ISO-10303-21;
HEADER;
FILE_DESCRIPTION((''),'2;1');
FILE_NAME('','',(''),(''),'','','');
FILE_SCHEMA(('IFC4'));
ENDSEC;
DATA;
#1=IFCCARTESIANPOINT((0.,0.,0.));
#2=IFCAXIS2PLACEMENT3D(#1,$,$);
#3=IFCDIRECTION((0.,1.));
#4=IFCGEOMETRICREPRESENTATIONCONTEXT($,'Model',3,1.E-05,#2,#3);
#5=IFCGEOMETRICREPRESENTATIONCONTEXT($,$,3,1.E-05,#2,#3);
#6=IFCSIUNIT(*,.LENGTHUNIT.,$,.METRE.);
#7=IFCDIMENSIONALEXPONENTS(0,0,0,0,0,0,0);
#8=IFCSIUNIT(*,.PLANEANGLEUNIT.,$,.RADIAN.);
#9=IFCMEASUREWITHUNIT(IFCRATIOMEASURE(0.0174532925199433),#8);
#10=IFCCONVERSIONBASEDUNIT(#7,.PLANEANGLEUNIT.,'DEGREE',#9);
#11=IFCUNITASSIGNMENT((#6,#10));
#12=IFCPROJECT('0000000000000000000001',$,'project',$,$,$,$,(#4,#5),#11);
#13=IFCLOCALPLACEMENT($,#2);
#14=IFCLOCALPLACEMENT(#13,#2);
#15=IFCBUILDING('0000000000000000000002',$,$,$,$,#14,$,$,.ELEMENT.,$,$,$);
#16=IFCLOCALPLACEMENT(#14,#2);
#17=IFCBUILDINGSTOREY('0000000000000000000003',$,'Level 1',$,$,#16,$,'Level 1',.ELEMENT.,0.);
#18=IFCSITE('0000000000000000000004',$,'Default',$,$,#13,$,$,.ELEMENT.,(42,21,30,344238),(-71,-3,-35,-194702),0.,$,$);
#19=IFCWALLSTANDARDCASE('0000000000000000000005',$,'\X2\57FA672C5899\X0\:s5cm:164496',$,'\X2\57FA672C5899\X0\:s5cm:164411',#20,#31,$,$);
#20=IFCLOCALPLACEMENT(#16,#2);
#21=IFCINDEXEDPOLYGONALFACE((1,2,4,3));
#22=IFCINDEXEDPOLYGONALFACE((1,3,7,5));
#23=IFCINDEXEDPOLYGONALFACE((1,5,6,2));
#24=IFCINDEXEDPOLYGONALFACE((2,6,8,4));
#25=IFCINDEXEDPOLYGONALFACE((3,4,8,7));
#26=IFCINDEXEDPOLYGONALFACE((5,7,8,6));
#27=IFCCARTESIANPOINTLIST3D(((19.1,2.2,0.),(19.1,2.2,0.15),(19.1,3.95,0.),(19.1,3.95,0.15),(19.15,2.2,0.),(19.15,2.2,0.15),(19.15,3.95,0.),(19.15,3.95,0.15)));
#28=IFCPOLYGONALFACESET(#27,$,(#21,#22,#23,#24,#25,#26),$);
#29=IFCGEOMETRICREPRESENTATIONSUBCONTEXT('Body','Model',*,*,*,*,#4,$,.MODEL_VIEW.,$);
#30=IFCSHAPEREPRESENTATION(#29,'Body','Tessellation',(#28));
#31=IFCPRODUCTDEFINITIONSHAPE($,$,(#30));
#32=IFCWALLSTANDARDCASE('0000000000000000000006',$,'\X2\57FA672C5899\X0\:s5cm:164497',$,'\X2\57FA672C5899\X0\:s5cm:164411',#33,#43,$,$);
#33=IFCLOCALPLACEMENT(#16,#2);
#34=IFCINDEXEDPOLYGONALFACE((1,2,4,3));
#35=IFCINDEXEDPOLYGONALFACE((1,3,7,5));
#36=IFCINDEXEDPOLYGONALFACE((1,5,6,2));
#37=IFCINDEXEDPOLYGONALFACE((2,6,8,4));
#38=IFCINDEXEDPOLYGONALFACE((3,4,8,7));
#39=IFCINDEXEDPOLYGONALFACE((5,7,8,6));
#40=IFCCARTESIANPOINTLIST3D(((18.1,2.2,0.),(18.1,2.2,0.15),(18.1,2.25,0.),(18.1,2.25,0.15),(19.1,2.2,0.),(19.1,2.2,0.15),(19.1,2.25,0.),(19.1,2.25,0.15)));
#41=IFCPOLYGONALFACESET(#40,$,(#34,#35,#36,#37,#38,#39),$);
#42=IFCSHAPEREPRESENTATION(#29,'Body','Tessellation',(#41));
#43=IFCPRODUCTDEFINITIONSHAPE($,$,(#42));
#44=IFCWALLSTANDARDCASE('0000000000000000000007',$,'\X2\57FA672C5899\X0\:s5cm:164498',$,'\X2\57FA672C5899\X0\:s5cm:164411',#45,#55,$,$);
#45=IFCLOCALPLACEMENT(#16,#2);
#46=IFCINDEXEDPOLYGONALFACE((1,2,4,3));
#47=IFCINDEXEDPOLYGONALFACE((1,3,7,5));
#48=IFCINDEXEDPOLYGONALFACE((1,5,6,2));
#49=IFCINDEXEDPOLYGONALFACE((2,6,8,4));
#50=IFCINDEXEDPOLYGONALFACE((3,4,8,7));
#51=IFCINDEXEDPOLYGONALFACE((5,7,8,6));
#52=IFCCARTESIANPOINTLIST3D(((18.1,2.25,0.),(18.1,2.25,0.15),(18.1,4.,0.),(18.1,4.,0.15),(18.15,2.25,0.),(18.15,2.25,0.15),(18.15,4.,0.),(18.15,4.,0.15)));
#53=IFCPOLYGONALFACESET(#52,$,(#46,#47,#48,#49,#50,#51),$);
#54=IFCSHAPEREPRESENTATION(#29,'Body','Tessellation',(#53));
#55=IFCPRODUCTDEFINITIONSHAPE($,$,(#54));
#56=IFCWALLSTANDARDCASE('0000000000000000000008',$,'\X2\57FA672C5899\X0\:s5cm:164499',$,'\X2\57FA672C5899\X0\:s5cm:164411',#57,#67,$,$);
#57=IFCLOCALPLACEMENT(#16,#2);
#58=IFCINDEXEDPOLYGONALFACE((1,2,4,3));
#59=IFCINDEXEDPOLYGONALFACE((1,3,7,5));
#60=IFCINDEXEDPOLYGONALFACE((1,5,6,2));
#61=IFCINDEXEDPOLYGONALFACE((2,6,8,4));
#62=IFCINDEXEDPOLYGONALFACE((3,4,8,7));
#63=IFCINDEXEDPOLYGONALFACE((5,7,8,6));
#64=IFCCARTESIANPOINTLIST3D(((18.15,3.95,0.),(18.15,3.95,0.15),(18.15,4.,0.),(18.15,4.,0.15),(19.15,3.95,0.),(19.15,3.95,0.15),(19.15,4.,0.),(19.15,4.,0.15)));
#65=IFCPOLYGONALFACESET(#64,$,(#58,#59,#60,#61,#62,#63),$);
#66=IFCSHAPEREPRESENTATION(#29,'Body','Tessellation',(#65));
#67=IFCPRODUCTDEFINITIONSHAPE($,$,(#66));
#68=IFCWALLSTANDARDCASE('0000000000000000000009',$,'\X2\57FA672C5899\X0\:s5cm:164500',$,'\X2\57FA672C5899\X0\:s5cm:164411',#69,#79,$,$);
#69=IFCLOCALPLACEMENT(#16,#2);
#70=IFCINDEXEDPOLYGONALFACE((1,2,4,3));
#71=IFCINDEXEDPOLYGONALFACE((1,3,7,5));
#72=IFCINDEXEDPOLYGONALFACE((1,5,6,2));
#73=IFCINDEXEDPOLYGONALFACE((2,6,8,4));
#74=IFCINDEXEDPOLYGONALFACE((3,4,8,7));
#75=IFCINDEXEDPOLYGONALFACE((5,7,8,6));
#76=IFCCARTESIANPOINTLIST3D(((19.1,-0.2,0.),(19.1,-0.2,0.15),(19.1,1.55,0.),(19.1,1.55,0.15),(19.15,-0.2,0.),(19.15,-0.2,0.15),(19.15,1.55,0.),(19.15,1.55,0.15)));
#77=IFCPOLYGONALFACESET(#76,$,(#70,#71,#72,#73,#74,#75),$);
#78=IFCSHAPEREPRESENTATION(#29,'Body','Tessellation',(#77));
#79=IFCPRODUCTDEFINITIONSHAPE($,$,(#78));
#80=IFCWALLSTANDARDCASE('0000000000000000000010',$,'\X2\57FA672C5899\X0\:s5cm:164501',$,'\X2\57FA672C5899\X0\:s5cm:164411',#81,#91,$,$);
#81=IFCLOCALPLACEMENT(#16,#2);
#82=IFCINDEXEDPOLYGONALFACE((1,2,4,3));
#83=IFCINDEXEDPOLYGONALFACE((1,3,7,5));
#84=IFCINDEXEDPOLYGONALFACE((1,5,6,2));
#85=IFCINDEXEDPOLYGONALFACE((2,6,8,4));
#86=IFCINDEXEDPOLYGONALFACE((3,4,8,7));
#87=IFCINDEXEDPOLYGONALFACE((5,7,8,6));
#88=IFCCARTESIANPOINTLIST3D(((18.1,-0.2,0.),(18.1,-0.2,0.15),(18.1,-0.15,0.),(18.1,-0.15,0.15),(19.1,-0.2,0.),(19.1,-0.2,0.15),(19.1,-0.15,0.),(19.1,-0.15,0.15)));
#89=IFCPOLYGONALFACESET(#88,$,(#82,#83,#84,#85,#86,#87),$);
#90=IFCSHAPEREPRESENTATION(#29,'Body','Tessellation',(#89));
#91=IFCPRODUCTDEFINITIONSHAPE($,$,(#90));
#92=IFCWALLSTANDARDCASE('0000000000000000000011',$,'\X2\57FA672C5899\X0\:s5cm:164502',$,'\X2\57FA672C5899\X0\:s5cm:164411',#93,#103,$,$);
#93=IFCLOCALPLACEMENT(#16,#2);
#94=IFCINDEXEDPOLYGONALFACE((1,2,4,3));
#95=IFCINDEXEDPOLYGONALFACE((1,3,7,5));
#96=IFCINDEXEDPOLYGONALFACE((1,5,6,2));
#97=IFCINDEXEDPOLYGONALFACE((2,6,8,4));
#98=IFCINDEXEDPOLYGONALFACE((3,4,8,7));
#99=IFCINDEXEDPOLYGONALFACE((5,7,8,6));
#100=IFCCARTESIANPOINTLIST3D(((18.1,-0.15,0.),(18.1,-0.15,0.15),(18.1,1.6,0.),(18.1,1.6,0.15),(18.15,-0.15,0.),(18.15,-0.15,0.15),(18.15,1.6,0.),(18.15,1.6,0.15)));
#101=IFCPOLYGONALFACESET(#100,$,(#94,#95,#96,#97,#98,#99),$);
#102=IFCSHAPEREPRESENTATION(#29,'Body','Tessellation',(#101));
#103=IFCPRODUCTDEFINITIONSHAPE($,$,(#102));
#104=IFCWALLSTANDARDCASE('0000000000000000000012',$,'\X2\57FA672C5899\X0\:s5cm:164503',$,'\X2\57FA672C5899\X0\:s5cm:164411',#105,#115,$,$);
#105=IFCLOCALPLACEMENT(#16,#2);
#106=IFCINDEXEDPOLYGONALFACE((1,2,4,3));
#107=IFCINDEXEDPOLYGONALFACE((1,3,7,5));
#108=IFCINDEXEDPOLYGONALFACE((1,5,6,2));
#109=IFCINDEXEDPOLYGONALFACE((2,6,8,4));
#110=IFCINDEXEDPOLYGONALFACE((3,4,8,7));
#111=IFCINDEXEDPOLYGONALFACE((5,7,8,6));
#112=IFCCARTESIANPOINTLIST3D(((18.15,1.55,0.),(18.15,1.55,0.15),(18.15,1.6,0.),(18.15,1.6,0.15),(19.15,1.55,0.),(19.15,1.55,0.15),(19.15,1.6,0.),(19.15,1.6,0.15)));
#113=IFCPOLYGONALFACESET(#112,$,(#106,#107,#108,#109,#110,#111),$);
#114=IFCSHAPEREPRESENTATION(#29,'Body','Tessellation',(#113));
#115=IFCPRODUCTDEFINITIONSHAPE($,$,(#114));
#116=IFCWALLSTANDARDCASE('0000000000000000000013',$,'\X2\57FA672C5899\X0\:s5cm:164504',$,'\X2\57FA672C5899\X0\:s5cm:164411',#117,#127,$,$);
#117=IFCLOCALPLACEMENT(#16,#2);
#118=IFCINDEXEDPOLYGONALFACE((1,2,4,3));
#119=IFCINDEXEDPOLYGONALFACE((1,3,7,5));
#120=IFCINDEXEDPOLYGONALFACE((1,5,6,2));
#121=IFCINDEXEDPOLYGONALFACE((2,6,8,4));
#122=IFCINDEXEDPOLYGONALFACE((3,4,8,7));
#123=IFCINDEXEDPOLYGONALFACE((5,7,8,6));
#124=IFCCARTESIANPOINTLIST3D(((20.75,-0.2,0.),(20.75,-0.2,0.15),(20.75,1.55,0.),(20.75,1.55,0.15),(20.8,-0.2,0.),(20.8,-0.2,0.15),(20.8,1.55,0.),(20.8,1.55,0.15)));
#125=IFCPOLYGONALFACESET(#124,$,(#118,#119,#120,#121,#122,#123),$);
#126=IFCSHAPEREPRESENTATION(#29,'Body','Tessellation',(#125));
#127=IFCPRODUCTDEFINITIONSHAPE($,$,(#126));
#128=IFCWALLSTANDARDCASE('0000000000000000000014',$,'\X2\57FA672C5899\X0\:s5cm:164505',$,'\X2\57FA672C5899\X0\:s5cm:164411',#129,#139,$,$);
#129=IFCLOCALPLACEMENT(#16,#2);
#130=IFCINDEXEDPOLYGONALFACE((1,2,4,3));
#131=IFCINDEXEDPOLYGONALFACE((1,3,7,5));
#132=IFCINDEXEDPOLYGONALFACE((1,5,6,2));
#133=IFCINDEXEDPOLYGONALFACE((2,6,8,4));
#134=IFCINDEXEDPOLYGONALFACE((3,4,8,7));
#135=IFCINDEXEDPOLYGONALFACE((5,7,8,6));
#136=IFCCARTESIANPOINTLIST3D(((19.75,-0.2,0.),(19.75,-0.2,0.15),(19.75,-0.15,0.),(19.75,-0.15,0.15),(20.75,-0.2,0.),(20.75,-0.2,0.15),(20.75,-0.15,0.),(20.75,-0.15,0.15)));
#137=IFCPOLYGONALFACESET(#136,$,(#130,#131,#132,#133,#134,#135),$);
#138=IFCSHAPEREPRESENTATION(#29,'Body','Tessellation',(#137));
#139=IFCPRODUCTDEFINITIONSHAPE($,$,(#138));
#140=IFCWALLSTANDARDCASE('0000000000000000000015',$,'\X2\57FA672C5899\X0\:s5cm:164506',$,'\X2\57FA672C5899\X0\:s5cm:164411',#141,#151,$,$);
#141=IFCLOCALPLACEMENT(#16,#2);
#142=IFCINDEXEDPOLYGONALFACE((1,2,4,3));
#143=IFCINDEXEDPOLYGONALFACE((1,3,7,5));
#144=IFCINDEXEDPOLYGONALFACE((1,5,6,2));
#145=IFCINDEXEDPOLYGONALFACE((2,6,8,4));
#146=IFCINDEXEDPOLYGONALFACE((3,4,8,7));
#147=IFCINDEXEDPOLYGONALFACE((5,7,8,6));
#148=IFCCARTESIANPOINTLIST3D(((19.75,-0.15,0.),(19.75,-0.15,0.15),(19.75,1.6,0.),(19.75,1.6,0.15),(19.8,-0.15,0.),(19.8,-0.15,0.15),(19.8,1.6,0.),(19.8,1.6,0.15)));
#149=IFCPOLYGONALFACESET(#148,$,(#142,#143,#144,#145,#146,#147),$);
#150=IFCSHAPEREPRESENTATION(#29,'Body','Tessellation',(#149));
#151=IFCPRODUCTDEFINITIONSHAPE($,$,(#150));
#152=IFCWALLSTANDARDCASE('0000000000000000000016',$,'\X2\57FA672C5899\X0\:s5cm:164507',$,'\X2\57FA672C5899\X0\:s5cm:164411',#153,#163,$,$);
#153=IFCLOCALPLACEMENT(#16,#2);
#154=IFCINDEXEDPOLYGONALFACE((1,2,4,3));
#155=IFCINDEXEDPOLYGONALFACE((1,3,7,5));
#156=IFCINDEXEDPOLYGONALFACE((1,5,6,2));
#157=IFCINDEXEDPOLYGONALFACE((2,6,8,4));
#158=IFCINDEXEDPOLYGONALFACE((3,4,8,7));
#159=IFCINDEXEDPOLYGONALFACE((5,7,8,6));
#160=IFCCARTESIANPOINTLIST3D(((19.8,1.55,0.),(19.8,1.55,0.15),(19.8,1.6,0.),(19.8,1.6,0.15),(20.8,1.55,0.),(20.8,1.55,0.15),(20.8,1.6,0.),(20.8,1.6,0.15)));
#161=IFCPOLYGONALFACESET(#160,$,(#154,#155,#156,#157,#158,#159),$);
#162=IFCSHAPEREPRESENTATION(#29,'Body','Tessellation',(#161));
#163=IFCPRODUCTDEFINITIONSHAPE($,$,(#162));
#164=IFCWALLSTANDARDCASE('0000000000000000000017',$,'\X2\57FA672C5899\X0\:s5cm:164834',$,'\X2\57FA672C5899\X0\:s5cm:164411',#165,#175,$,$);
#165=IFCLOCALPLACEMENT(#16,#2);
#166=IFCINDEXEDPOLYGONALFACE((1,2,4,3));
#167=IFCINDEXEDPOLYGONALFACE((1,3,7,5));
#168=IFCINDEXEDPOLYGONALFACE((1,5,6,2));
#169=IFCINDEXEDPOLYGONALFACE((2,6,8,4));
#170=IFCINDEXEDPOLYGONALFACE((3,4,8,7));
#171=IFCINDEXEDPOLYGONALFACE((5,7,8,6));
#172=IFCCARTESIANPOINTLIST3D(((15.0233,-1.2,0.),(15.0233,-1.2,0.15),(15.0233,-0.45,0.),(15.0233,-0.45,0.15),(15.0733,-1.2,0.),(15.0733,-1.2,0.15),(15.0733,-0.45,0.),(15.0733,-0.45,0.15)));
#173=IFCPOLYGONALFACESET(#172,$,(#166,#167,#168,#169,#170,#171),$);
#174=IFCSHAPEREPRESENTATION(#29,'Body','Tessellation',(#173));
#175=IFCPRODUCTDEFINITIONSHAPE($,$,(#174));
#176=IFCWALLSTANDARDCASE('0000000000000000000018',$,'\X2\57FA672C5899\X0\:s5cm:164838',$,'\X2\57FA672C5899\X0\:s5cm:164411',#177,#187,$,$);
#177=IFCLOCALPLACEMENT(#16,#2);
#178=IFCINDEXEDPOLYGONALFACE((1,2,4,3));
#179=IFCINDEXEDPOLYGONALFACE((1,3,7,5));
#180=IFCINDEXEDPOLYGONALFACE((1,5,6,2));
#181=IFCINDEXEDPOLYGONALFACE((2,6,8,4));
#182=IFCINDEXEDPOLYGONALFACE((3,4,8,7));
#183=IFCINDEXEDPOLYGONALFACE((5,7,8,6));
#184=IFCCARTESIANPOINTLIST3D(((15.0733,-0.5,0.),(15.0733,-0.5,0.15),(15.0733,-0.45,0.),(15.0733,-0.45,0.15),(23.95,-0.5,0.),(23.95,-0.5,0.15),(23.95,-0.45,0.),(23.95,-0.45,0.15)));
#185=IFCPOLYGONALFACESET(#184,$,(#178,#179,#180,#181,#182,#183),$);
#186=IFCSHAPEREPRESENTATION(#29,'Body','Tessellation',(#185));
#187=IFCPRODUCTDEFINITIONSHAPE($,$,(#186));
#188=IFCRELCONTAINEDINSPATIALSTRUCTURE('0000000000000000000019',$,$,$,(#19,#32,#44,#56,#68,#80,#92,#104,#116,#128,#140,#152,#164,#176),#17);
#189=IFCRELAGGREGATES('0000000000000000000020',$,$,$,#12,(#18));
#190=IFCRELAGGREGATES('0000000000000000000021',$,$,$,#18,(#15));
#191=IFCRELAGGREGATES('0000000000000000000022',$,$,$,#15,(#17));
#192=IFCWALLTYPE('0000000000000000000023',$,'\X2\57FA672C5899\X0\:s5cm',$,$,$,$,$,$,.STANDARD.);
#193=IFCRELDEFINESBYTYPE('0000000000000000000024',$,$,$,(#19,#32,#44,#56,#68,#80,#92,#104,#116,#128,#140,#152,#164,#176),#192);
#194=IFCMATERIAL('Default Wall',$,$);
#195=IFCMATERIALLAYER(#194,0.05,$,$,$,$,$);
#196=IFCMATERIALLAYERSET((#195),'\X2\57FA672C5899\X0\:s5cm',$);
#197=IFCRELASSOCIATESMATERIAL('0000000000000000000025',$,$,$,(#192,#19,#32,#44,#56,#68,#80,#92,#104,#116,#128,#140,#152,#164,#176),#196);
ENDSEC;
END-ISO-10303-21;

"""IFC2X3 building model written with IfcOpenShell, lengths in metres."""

from ifc_helpers import new_model, entity, si_unit, converted_unit, direction, frame, frame_2d, origin, place, context, subcontext, project, spatial, rectangle, extrude, material, layer, layer_set, layer_usage, type_object, element, save


model = new_model("IFC2X3")

# Units and contexts
model_context = context("Model", 3, precision=1e-05, world=origin(), true_north=direction((0.0, 1.0)))
context_of_model = context(None, 3, precision=1e-05, world=origin(), true_north=direction((0.0, 1.0)))
body_context = subcontext(model_context, "Body", "Model", "MODEL_VIEW")
ifc_project = project(units=[si_unit("LENGTHUNIT", "METRE"), converted_unit("PLANEANGLEUNIT", "DEGREE", entity("IfcRatioMeasure", 0.0174532925199433), si_unit("PLANEANGLEUNIT", "RADIAN"), dimensions=[0, 0, 0, 0, 0, 0, 0])], contexts=[model_context, context_of_model])

# Site, building, storey
site_placement = place(None, origin())
site = spatial("IfcSite", under=ifc_project, at=site_placement, Name="Default", CompositionType="ELEMENT", RefLatitude=(42, 21, 30, 344238), RefLongitude=(-71, -3, -35, -194702), RefElevation=0.0)
building_placement = place(site_placement, origin())
building = spatial("IfcBuilding", under=site, at=building_placement, CompositionType="ELEMENT")
storey_placement = place(building_placement, origin())
storey = spatial("IfcBuildingStorey", under=building, at=storey_placement, Name="Level 1", LongName="Level 1", CompositionType="ELEMENT", Elevation=0.0)

# Walls
ifc_material_1 = material(Name="Default Wall")
ifc_layer_1 = layer(ifc_material_1, 0.05)
ifc_layer_set_1 = layer_set([ifc_layer_1], Name="基本墙:s5cm")
wall_type = type_object("IfcWallType", Name="基本墙:s5cm", PredefinedType="STANDARD", material=ifc_layer_set_1)
ifc_layer_usage_1 = layer_usage(ifc_layer_set_1, "AXIS2", "NEGATIVE", 0.025)
wall_1_placement = place(storey_placement, frame((19.125, 3.95, 0.0), z_axis=(0.0, 0.0, 1.0), x_axis=(0.0, -1.0, 0.0)))
element("IfcWallStandardCase", 1, at=wall_1_placement, inside=storey, type_object=wall_type, material=ifc_layer_usage_1, Name="基本墙:s5cm:164496", ObjectType="基本墙:s5cm:164411", context=body_context, shape_type="SweptSolid", body=[
    extrude(rectangle(XDim=1.75, YDim=0.05, at=frame_2d((0.875, 0.0), x_axis=(-1.0, 0.0))), origin(), (0.0, 0.0, 1.0), 0.15),
])
ifc_layer_usage_2 = layer_usage(ifc_layer_set_1, "AXIS2", "NEGATIVE", 0.025)
wall_2_placement = place(storey_placement, frame((19.1, 2.225, 0.0), z_axis=(0.0, 0.0, 1.0), x_axis=(-1.0, 0.0, 0.0)))
element("IfcWallStandardCase", 2, at=wall_2_placement, inside=storey, type_object=wall_type, material=ifc_layer_usage_2, Name="基本墙:s5cm:164497", ObjectType="基本墙:s5cm:164411", context=body_context, shape_type="SweptSolid", body=[
    extrude(rectangle(XDim=1.0, YDim=0.05, at=frame_2d((0.5, 0.0), x_axis=(-1.0, 0.0))), origin(), (0.0, 0.0, 1.0), 0.15),
])
ifc_layer_usage_3 = layer_usage(ifc_layer_set_1, "AXIS2", "NEGATIVE", 0.025)
wall_3_placement = place(storey_placement, frame((18.125, 2.25, 0.0), z_axis=(0.0, 0.0, 1.0), x_axis=(0.0, 1.0, 0.0)))
element("IfcWallStandardCase", 3, at=wall_3_placement, inside=storey, type_object=wall_type, material=ifc_layer_usage_3, Name="基本墙:s5cm:164498", ObjectType="基本墙:s5cm:164411", context=body_context, shape_type="SweptSolid", body=[
    extrude(rectangle(XDim=1.75, YDim=0.05, at=frame_2d((0.875, 0.0), x_axis=(-1.0, 0.0))), origin(), (0.0, 0.0, 1.0), 0.15),
])
ifc_layer_usage_4 = layer_usage(ifc_layer_set_1, "AXIS2", "NEGATIVE", 0.025)
wall_4_placement = place(storey_placement, frame((18.15, 3.975, 0.0)))
element("IfcWallStandardCase", 4, at=wall_4_placement, inside=storey, type_object=wall_type, material=ifc_layer_usage_4, Name="基本墙:s5cm:164499", ObjectType="基本墙:s5cm:164411", context=body_context, shape_type="SweptSolid", body=[
    extrude(rectangle(XDim=1.0, YDim=0.05, at=frame_2d((0.5, 0.0), x_axis=(-1.0, 0.0))), origin(), (0.0, 0.0, 1.0), 0.15),
])
ifc_layer_usage_5 = layer_usage(ifc_layer_set_1, "AXIS2", "NEGATIVE", 0.025)
wall_5_placement = place(storey_placement, frame((19.125, 1.55, 0.0), z_axis=(0.0, 0.0, 1.0), x_axis=(0.0, -1.0, 0.0)))
element("IfcWallStandardCase", 5, at=wall_5_placement, inside=storey, type_object=wall_type, material=ifc_layer_usage_5, Name="基本墙:s5cm:164500", ObjectType="基本墙:s5cm:164411", context=body_context, shape_type="SweptSolid", body=[
    extrude(rectangle(XDim=1.75, YDim=0.05, at=frame_2d((0.875, 0.0), x_axis=(-1.0, 0.0))), origin(), (0.0, 0.0, 1.0), 0.15),
])
ifc_layer_usage_6 = layer_usage(ifc_layer_set_1, "AXIS2", "NEGATIVE", 0.025)
wall_6_placement = place(storey_placement, frame((19.1, -0.175, 0.0), z_axis=(0.0, 0.0, 1.0), x_axis=(-1.0, 0.0, 0.0)))
element("IfcWallStandardCase", 6, at=wall_6_placement, inside=storey, type_object=wall_type, material=ifc_layer_usage_6, Name="基本墙:s5cm:164501", ObjectType="基本墙:s5cm:164411", context=body_context, shape_type="SweptSolid", body=[
    extrude(rectangle(XDim=1.0, YDim=0.05, at=frame_2d((0.5, 0.0), x_axis=(-1.0, 0.0))), origin(), (0.0, 0.0, 1.0), 0.15),
])
ifc_layer_usage_7 = layer_usage(ifc_layer_set_1, "AXIS2", "NEGATIVE", 0.025)
wall_7_placement = place(storey_placement, frame((18.125, -0.15, 0.0), z_axis=(0.0, 0.0, 1.0), x_axis=(0.0, 1.0, 0.0)))
element("IfcWallStandardCase", 7, at=wall_7_placement, inside=storey, type_object=wall_type, material=ifc_layer_usage_7, Name="基本墙:s5cm:164502", ObjectType="基本墙:s5cm:164411", context=body_context, shape_type="SweptSolid", body=[
    extrude(rectangle(XDim=1.75, YDim=0.05, at=frame_2d((0.875, 0.0), x_axis=(-1.0, 0.0))), origin(), (0.0, 0.0, 1.0), 0.15),
])
ifc_layer_usage_8 = layer_usage(ifc_layer_set_1, "AXIS2", "NEGATIVE", 0.025)
wall_8_placement = place(storey_placement, frame((18.15, 1.575, 0.0)))
element("IfcWallStandardCase", 8, at=wall_8_placement, inside=storey, type_object=wall_type, material=ifc_layer_usage_8, Name="基本墙:s5cm:164503", ObjectType="基本墙:s5cm:164411", context=body_context, shape_type="SweptSolid", body=[
    extrude(rectangle(XDim=1.0, YDim=0.05, at=frame_2d((0.5, 0.0), x_axis=(-1.0, 0.0))), origin(), (0.0, 0.0, 1.0), 0.15),
])
ifc_layer_usage_9 = layer_usage(ifc_layer_set_1, "AXIS2", "NEGATIVE", 0.025)
wall_9_placement = place(storey_placement, frame((20.775, 1.55, 0.0), z_axis=(0.0, 0.0, 1.0), x_axis=(0.0, -1.0, 0.0)))
element("IfcWallStandardCase", 9, at=wall_9_placement, inside=storey, type_object=wall_type, material=ifc_layer_usage_9, Name="基本墙:s5cm:164504", ObjectType="基本墙:s5cm:164411", context=body_context, shape_type="SweptSolid", body=[
    extrude(rectangle(XDim=1.75, YDim=0.05, at=frame_2d((0.875, 0.0), x_axis=(-1.0, 0.0))), origin(), (0.0, 0.0, 1.0), 0.15),
])
ifc_layer_usage_10 = layer_usage(ifc_layer_set_1, "AXIS2", "NEGATIVE", 0.025)
wall_10_placement = place(storey_placement, frame((20.75, -0.175, 0.0), z_axis=(0.0, 0.0, 1.0), x_axis=(-1.0, 0.0, 0.0)))
element("IfcWallStandardCase", 10, at=wall_10_placement, inside=storey, type_object=wall_type, material=ifc_layer_usage_10, Name="基本墙:s5cm:164505", ObjectType="基本墙:s5cm:164411", context=body_context, shape_type="SweptSolid", body=[
    extrude(rectangle(XDim=1.0, YDim=0.05, at=frame_2d((0.5, 0.0), x_axis=(-1.0, 0.0))), origin(), (0.0, 0.0, 1.0), 0.15),
])
ifc_layer_usage_11 = layer_usage(ifc_layer_set_1, "AXIS2", "NEGATIVE", 0.025)
wall_11_placement = place(storey_placement, frame((19.775, -0.15, 0.0), z_axis=(0.0, 0.0, 1.0), x_axis=(0.0, 1.0, 0.0)))
element("IfcWallStandardCase", 11, at=wall_11_placement, inside=storey, type_object=wall_type, material=ifc_layer_usage_11, Name="基本墙:s5cm:164506", ObjectType="基本墙:s5cm:164411", context=body_context, shape_type="SweptSolid", body=[
    extrude(rectangle(XDim=1.75, YDim=0.05, at=frame_2d((0.875, 0.0), x_axis=(-1.0, 0.0))), origin(), (0.0, 0.0, 1.0), 0.15),
])
ifc_layer_usage_12 = layer_usage(ifc_layer_set_1, "AXIS2", "NEGATIVE", 0.025)
wall_12_placement = place(storey_placement, frame((19.8, 1.575, 0.0)))
element("IfcWallStandardCase", 12, at=wall_12_placement, inside=storey, type_object=wall_type, material=ifc_layer_usage_12, Name="基本墙:s5cm:164507", ObjectType="基本墙:s5cm:164411", context=body_context, shape_type="SweptSolid", body=[
    extrude(rectangle(XDim=1.0, YDim=0.05, at=frame_2d((0.5, 0.0), x_axis=(-1.0, 0.0))), origin(), (0.0, 0.0, 1.0), 0.15),
])
ifc_layer_usage_13 = layer_usage(ifc_layer_set_1, "AXIS2", "NEGATIVE", 0.025)
wall_13_placement = place(storey_placement, frame((15.0483, -1.2, 0.0), z_axis=(0.0, 0.0, 1.0), x_axis=(0.0, 1.0, 0.0)))
element("IfcWallStandardCase", 13, at=wall_13_placement, inside=storey, type_object=wall_type, material=ifc_layer_usage_13, Name="基本墙:s5cm:164834", ObjectType="基本墙:s5cm:164411", context=body_context, shape_type="SweptSolid", body=[
    extrude(rectangle(XDim=0.75, YDim=0.05, at=frame_2d((0.375, 0.0), x_axis=(-1.0, 0.0))), origin(), (0.0, 0.0, 1.0), 0.15),
])
ifc_layer_usage_14 = layer_usage(ifc_layer_set_1, "AXIS2", "NEGATIVE", 0.025)
wall_14_placement = place(storey_placement, frame((15.0733, -0.475, 0.0)))
element("IfcWallStandardCase", 14, at=wall_14_placement, inside=storey, type_object=wall_type, material=ifc_layer_usage_14, Name="基本墙:s5cm:164838", ObjectType="基本墙:s5cm:164411", context=body_context, shape_type="SweptSolid", body=[
    extrude(rectangle(XDim=8.8767, YDim=0.05, at=frame_2d((4.4384, 0.0), x_axis=(-1.0, 0.0))), origin(), (0.0, 0.0, 1.0), 0.15),
])

save(model, "model.ifc")
